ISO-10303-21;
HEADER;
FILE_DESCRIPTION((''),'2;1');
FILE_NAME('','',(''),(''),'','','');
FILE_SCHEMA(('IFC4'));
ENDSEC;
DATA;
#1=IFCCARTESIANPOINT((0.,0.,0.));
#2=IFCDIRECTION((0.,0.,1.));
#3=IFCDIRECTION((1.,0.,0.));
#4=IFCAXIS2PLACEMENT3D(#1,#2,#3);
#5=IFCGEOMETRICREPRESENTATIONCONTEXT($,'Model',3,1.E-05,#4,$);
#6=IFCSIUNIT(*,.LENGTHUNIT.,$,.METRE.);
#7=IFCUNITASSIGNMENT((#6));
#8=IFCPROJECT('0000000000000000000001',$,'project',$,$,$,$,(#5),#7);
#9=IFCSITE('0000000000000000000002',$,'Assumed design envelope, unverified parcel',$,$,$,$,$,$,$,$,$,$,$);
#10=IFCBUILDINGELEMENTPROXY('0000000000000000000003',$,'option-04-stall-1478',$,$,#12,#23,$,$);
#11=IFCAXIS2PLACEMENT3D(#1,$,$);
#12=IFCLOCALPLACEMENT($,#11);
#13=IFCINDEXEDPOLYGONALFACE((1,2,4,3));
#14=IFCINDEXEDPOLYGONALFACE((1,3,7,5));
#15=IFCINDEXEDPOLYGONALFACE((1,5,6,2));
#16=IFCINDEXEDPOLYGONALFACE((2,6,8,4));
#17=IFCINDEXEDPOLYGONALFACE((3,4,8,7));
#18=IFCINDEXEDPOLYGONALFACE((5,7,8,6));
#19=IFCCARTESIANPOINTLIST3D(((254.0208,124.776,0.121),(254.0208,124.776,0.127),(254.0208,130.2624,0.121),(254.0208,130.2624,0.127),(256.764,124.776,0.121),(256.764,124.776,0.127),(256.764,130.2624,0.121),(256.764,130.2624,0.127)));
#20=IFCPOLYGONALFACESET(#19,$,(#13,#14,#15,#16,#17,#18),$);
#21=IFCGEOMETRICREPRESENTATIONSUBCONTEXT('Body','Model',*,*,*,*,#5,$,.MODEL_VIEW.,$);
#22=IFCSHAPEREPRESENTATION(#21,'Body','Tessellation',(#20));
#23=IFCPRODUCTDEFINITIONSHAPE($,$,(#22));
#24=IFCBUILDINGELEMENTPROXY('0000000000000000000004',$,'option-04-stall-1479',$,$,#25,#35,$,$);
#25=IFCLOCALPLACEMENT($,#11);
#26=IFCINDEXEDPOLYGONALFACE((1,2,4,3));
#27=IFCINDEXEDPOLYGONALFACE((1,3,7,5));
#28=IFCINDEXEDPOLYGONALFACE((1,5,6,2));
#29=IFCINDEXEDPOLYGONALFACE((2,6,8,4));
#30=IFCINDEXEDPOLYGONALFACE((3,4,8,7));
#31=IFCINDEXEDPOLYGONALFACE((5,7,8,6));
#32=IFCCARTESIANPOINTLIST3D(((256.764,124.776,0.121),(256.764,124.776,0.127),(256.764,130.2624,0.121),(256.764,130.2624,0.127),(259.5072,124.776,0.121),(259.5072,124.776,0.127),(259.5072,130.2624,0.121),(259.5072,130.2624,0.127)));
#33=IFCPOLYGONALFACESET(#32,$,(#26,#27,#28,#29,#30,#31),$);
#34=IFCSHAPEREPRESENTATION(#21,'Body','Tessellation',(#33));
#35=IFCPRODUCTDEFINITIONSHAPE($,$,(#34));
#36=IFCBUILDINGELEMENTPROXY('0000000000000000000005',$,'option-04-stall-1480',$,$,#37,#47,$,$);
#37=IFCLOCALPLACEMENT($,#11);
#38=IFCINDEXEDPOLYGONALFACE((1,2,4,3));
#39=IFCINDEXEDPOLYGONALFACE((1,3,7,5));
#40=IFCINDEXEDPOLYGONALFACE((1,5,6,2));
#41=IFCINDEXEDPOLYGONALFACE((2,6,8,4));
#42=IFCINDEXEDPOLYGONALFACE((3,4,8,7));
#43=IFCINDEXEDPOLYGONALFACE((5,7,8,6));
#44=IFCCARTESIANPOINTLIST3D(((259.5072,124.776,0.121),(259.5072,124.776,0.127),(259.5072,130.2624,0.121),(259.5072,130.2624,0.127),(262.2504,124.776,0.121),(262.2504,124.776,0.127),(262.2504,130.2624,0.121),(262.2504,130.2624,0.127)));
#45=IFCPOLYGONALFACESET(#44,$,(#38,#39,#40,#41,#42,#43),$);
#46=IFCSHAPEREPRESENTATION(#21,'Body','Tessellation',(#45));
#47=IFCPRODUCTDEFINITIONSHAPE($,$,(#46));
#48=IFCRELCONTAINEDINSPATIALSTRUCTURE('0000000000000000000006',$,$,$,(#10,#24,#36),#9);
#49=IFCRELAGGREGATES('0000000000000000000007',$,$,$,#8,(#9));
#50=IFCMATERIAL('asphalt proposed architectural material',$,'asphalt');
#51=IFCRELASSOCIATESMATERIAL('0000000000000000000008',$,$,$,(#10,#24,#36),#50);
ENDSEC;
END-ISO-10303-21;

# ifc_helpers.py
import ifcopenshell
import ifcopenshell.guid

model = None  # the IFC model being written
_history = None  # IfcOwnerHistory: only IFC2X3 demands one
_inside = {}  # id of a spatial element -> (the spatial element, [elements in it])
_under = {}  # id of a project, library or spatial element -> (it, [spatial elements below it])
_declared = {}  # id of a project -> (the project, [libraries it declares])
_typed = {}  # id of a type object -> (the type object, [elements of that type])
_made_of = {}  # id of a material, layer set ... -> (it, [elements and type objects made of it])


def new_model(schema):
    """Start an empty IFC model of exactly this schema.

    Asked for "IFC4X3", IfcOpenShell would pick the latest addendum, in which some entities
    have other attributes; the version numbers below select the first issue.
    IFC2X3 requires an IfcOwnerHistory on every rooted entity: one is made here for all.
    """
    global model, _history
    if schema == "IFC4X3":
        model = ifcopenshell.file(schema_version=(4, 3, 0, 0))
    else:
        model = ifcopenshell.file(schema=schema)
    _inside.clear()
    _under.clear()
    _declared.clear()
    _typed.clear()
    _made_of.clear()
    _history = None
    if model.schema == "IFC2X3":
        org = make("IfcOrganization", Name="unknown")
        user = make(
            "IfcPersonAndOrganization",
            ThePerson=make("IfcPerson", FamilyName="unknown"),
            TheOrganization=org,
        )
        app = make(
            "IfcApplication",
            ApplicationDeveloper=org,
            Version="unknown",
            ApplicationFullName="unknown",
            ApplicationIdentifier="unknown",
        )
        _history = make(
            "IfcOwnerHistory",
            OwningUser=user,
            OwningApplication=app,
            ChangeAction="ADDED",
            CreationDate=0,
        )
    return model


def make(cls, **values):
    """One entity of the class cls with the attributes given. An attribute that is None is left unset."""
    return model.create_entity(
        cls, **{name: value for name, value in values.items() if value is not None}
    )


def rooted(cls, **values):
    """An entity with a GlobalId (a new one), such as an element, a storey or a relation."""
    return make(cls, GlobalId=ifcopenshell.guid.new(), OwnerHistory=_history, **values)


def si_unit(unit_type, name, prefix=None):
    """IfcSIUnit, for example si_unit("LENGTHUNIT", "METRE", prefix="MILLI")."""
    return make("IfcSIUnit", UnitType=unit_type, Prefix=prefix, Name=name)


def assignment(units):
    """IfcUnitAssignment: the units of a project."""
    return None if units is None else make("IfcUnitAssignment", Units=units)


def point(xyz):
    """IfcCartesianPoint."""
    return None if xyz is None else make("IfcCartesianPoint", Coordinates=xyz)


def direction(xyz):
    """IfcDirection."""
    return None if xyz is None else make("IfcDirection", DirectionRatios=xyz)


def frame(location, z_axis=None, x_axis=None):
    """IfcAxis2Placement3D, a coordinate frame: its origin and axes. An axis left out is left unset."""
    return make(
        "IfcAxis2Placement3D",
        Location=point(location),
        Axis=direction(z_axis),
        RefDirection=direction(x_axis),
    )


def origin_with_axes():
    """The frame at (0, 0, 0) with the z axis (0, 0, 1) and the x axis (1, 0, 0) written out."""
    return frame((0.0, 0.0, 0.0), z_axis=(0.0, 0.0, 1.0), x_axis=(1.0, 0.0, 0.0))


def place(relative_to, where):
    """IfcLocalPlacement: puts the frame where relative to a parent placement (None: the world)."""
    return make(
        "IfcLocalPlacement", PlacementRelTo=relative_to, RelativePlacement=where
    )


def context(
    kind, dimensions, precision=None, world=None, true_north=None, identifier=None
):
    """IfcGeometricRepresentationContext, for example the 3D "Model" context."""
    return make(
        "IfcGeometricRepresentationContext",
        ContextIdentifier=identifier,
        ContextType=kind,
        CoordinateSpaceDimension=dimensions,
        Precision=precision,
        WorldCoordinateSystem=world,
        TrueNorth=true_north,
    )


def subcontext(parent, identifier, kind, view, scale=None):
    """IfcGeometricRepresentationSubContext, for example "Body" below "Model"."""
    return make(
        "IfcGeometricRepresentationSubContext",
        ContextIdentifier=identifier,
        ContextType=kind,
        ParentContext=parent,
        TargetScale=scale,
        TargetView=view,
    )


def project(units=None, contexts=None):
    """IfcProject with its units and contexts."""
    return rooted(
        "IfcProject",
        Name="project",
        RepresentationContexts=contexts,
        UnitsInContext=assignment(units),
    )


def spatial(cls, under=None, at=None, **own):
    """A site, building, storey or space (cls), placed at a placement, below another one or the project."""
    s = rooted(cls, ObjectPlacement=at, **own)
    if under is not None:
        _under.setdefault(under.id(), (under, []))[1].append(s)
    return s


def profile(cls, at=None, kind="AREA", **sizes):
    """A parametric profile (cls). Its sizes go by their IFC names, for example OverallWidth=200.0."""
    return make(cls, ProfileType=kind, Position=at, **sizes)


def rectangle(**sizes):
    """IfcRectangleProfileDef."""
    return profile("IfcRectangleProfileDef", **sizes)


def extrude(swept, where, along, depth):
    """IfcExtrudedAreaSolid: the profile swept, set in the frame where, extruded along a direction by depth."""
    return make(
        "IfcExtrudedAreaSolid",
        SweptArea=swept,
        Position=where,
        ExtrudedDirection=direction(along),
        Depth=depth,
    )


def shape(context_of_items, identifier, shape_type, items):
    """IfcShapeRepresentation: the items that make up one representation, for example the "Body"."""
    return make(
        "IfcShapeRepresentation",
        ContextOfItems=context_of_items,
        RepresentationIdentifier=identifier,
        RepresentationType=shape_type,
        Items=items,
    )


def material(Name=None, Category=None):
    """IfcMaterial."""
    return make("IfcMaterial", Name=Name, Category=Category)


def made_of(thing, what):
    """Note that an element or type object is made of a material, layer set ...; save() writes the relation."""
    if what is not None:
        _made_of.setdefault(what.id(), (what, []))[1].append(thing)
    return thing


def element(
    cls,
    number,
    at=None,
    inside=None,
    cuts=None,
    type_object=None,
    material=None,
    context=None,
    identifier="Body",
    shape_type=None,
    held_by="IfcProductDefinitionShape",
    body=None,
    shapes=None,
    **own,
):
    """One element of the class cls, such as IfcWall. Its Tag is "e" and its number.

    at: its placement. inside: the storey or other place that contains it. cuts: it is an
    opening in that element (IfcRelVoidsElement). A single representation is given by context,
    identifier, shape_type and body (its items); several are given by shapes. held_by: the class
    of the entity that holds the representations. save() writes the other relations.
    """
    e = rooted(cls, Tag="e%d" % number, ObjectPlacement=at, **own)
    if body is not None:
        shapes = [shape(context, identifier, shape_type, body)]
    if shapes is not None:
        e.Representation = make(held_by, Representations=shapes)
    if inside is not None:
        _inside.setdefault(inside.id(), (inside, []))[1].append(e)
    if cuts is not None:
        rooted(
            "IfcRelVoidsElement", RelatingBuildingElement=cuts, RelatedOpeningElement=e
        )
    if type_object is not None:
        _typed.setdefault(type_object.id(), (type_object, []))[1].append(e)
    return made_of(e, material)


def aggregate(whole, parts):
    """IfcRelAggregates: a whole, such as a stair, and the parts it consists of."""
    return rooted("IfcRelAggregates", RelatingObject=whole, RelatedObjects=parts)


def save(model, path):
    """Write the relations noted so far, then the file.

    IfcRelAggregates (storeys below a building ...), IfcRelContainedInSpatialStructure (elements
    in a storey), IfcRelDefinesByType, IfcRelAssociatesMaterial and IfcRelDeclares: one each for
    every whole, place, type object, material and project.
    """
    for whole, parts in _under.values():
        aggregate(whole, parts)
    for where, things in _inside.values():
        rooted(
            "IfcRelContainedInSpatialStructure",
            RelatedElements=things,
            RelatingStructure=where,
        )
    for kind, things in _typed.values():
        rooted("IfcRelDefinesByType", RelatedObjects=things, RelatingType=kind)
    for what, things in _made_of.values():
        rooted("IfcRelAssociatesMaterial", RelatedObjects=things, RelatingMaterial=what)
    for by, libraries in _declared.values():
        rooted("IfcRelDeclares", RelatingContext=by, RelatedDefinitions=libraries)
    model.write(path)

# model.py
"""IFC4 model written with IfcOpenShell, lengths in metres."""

from ifc_helpers import new_model, si_unit, frame, origin_with_axes, place, context, subcontext, project, spatial, rectangle, extrude, material, element, save


model = new_model("IFC4")

# Units and contexts
model_context = context("Model", 3, precision=1e-05, world=origin_with_axes())
body_context = subcontext(model_context, "Body", "Model", "MODEL_VIEW")
ifc_project = project(units=[si_unit("LENGTHUNIT", "METRE")], contexts=[model_context])

# Site
site = spatial("IfcSite", under=ifc_project, Name="Assumed design envelope, unverified parcel")

# Building element proxies
ifc_material = material(Name="asphalt proposed architectural material", Category="asphalt")
for number, where, z_axis, x_axis, name in (
    (1, (255.3924, 127.5192, 0.121), (0.0, 0.0, 1.0), (1.0, 0.0, 0.0), "option-04-stall-1478"),
    (2, (258.1356, 127.5192, 0.121), (0.0, 0.0, 1.0), (1.0, 0.0, 0.0), "option-04-stall-1479"),
    (3, (260.8788, 127.5192, 0.121), (0.0, 0.0, 1.0), (1.0, 0.0, 0.0), "option-04-stall-1480"),
):
    element("IfcBuildingElementProxy", number, at=place(None, frame(where, z_axis=z_axis, x_axis=x_axis)), inside=site, material=ifc_material, Name=name, context=body_context, shape_type="SweptSolid", body=[
        extrude(rectangle(XDim=2.7432, YDim=5.4864), origin_with_axes(), (0.0, 0.0, 1.0), 0.006),
    ])

save(model, "model.ifc")
